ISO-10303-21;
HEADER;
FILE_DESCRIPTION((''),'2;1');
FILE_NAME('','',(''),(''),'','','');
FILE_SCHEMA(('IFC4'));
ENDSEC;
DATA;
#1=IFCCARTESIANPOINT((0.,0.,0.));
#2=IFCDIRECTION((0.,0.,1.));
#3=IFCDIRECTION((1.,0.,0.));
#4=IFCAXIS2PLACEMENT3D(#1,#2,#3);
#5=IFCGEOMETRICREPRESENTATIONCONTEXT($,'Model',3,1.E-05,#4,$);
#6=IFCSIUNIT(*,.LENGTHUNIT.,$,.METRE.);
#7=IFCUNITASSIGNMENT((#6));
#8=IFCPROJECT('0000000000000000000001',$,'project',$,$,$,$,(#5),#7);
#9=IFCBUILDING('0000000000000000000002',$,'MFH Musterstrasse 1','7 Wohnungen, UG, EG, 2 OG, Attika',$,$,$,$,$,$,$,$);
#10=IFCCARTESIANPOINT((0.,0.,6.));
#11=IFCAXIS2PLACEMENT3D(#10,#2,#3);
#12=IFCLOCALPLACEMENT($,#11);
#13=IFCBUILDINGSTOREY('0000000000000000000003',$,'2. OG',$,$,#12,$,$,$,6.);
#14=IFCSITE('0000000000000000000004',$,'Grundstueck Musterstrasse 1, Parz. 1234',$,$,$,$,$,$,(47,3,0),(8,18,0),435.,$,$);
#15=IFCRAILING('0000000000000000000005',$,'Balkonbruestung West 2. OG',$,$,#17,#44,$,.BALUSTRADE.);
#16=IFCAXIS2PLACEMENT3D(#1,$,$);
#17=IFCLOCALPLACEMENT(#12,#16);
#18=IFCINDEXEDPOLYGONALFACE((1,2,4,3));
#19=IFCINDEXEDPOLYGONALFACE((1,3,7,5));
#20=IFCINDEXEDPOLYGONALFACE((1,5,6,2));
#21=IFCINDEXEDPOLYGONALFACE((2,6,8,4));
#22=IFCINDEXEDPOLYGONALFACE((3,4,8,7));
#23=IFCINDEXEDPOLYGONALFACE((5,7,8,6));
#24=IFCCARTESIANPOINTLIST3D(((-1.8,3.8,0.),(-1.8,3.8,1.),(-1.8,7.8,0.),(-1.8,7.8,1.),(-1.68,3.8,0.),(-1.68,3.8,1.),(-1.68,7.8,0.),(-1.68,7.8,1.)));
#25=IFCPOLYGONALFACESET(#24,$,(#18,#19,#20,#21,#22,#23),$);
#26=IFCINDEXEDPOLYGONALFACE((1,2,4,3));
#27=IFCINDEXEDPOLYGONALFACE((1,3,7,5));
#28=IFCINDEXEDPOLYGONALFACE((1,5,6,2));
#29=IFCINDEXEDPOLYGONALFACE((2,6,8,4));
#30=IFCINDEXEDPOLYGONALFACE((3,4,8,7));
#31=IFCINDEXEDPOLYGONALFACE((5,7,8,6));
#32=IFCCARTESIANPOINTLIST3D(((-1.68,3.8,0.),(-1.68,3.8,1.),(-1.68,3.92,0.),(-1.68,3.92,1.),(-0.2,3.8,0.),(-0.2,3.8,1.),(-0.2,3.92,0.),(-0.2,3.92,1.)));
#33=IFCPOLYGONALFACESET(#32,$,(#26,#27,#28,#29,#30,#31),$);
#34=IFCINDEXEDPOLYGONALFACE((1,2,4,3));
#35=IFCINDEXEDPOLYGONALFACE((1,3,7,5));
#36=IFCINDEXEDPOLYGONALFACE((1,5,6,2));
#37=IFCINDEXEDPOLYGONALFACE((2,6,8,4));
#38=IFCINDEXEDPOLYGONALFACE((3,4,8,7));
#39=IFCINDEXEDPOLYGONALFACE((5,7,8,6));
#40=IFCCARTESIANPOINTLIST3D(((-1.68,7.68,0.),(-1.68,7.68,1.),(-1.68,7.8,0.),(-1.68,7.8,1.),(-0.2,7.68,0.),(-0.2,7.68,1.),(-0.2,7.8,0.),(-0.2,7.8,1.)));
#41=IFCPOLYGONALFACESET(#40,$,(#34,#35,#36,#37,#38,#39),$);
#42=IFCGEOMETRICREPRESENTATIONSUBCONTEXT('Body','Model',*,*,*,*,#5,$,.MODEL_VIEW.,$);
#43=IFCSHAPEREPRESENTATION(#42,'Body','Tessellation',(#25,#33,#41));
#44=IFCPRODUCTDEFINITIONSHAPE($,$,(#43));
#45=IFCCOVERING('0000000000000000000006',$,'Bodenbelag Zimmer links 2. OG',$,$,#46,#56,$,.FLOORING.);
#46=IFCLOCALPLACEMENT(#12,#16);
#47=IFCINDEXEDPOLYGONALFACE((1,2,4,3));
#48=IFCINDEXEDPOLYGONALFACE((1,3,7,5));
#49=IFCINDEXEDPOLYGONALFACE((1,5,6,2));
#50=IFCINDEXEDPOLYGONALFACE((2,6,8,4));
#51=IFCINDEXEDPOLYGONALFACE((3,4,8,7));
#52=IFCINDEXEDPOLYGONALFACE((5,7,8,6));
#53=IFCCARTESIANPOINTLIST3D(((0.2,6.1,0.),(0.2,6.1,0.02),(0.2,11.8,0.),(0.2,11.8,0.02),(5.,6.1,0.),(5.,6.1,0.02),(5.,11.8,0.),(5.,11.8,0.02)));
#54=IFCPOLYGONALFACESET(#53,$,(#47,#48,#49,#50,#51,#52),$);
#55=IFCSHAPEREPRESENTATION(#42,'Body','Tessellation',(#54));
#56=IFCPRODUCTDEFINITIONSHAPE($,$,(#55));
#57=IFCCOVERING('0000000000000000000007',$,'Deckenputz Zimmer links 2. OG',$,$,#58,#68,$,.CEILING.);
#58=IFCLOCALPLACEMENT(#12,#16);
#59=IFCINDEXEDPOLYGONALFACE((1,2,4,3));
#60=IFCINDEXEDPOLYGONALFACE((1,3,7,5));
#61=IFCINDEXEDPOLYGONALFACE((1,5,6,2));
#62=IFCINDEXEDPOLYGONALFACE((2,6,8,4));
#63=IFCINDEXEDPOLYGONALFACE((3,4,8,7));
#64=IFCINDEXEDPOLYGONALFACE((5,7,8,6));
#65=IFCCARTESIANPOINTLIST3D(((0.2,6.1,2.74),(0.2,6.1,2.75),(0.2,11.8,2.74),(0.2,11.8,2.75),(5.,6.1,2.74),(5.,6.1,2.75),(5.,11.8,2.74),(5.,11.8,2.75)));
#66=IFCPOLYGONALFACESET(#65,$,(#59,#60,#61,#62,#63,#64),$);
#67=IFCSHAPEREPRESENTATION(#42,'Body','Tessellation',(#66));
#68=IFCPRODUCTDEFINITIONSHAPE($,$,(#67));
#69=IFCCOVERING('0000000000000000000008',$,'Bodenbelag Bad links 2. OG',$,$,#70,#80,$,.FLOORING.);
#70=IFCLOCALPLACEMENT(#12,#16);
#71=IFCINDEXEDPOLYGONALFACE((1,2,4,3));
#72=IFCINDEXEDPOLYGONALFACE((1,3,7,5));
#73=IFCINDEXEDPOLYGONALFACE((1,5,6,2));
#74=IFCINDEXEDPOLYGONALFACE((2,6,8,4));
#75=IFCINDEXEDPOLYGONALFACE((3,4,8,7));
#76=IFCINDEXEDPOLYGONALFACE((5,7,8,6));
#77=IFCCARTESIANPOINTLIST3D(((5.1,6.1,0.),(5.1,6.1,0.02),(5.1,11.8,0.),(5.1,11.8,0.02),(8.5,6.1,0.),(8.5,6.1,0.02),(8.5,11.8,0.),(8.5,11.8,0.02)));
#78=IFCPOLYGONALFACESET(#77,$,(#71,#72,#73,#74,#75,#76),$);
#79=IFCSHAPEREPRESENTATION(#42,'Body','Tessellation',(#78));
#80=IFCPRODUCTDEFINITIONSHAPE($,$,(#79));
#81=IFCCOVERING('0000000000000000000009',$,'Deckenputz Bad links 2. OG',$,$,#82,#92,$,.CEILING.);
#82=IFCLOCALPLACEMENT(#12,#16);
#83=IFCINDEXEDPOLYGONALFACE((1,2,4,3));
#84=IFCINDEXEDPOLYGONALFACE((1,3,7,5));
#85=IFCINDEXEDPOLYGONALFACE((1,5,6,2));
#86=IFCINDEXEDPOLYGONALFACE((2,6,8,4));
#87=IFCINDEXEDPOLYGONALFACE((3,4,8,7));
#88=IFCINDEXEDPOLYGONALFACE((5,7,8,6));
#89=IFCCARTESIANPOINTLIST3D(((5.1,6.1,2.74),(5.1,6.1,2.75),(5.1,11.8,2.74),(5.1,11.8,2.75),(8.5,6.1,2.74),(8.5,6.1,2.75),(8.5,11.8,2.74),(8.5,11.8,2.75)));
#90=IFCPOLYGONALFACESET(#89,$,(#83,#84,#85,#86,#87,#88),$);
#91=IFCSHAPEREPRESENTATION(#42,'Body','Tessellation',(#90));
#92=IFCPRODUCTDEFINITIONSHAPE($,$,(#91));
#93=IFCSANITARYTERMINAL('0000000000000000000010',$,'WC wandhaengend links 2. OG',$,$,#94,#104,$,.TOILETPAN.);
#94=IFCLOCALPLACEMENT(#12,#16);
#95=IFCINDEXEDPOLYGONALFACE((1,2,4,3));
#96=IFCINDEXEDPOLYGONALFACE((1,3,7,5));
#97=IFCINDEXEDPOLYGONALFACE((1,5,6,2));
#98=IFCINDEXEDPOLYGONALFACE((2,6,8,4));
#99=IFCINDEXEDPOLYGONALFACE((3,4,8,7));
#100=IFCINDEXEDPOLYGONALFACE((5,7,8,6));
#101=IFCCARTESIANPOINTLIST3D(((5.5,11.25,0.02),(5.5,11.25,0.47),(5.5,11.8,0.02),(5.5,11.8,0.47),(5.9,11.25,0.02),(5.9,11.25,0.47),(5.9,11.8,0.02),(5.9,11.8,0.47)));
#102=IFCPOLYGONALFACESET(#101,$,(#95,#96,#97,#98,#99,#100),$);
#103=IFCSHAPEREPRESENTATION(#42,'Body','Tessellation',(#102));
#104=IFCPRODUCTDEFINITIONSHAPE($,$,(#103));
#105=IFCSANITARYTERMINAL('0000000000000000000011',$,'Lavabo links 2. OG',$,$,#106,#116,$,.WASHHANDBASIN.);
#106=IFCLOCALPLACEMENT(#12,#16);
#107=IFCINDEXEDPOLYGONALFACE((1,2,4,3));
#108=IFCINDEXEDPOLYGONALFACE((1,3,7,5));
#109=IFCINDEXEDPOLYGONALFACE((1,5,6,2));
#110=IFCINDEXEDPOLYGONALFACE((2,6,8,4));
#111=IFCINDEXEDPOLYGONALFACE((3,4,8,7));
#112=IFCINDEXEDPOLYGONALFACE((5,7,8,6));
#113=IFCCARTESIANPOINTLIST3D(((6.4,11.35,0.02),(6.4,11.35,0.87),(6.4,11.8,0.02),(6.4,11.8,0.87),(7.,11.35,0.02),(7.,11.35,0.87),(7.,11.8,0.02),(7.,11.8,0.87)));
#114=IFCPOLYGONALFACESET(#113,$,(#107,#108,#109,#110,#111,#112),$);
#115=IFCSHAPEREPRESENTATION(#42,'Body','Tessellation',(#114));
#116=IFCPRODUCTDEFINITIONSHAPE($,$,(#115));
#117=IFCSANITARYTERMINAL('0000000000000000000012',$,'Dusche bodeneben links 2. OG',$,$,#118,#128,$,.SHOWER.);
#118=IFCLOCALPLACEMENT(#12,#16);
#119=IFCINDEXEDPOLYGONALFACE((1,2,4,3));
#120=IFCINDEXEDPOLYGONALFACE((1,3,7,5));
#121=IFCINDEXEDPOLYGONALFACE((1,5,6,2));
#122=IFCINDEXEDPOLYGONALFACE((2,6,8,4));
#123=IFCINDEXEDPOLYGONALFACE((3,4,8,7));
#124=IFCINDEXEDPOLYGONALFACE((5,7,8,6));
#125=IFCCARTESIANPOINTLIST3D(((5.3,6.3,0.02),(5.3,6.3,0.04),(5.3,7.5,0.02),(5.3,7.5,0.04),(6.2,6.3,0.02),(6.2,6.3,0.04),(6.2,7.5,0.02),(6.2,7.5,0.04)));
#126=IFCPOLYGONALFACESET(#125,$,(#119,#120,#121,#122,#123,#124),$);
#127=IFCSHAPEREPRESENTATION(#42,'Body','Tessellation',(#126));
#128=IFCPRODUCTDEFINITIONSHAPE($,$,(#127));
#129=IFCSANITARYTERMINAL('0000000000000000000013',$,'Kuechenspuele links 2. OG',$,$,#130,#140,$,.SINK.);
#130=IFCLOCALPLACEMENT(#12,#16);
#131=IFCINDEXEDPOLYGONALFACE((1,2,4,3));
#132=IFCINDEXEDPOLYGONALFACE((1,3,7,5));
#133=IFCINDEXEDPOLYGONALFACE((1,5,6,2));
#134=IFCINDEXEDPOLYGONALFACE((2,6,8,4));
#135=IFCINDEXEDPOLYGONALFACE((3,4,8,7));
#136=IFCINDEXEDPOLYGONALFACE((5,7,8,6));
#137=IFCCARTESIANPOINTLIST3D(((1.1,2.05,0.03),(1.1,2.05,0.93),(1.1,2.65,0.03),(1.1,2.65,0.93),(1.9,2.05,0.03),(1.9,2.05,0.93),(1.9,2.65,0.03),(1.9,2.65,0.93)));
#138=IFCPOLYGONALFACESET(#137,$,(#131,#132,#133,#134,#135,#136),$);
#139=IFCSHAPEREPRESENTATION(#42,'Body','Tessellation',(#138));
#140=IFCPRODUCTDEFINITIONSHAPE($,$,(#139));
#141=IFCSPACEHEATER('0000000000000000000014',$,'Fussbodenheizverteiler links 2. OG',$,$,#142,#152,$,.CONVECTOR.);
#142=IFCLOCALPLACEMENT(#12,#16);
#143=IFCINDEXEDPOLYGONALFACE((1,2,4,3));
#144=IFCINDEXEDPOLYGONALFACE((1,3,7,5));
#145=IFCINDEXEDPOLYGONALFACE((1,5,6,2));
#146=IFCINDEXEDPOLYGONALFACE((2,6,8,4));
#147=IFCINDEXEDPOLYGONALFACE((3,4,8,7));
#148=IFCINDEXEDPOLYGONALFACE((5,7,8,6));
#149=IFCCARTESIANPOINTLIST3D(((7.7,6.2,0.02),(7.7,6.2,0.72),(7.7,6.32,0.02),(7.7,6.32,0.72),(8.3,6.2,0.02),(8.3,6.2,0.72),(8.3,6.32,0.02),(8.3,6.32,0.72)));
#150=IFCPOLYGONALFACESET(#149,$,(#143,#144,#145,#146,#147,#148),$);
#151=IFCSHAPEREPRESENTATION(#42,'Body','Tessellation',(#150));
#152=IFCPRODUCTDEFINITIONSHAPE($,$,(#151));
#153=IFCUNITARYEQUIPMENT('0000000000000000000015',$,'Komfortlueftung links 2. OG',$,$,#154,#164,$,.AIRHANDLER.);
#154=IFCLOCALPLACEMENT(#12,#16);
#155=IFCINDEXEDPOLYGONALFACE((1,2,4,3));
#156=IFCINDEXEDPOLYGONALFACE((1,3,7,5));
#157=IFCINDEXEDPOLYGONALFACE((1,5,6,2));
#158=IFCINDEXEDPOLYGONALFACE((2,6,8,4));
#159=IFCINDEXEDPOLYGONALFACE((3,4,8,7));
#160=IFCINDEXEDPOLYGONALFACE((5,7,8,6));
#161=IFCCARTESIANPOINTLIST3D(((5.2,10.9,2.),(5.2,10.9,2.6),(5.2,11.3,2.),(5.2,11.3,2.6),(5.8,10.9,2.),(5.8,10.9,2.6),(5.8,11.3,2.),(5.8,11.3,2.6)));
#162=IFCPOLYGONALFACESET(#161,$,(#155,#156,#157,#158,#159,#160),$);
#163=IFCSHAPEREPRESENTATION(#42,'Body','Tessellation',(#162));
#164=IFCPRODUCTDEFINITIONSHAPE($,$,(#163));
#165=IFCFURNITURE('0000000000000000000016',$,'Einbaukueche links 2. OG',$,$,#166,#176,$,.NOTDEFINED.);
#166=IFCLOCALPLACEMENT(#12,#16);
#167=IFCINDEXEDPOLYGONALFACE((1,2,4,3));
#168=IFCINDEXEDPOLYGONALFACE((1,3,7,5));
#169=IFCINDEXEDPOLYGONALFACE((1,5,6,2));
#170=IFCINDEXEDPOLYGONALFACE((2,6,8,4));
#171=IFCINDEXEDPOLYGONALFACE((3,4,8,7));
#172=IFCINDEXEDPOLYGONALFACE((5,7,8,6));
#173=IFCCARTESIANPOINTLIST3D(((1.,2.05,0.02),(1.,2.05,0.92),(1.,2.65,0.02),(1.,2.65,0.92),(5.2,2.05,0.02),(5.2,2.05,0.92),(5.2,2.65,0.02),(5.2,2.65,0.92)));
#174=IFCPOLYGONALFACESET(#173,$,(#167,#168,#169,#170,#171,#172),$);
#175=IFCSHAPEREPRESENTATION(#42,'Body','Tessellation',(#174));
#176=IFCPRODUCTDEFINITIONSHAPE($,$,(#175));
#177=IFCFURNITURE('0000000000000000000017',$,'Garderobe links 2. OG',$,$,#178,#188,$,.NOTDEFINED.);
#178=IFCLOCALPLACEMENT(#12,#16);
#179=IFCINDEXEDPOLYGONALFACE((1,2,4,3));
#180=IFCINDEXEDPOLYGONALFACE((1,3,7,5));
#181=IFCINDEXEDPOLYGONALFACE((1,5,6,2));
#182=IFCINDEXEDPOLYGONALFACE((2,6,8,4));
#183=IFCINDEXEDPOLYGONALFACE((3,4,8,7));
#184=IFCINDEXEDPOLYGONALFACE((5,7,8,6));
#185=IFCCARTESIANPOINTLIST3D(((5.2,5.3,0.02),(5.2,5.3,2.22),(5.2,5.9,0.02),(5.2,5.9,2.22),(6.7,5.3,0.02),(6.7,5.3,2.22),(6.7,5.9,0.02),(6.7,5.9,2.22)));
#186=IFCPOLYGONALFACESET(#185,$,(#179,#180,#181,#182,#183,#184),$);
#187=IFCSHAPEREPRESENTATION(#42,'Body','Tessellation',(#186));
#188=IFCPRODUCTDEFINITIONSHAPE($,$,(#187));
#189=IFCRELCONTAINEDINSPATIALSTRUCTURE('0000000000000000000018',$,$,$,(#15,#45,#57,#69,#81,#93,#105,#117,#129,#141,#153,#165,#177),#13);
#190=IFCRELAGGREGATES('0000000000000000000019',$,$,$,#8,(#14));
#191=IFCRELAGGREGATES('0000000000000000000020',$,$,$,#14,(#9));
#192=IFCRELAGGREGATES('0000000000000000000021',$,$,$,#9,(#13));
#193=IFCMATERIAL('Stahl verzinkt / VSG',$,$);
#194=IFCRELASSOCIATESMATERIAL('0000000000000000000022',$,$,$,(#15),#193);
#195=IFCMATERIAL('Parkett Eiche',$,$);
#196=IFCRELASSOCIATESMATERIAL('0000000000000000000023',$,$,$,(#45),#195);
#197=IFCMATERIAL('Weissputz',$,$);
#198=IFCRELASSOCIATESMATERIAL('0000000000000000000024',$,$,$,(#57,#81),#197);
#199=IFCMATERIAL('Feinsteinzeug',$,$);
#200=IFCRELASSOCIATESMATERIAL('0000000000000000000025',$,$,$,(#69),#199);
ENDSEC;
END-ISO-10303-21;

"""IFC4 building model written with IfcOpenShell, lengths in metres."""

from ifc_helpers import new_model, si_unit, frame, frame_2d, origin_with_axes, place, context, subcontext, project, spatial, rectangle, extrude, material, element, save


model = new_model("IFC4")

# Units and contexts
model_context = context("Model", 3, precision=1e-05, world=origin_with_axes())
body_context = subcontext(model_context, "Body", "Model", "MODEL_VIEW")
ifc_project = project(units=[si_unit("LENGTHUNIT", "METRE")], contexts=[model_context])

# Site, building, storey
site = spatial("IfcSite", under=ifc_project, Name="Grundstueck Musterstrasse 1, Parz. 1234", RefLatitude=(47, 3, 0), RefLongitude=(8, 18, 0), RefElevation=435.0)
building = spatial("IfcBuilding", under=site, Name="MFH Musterstrasse 1", Description="7 Wohnungen, UG, EG, 2 OG, Attika")
storey_placement = place(None, frame((0.0, 0.0, 6.0), z_axis=(0.0, 0.0, 1.0), x_axis=(1.0, 0.0, 0.0)))
storey = spatial("IfcBuildingStorey", under=building, at=storey_placement, Name="2. OG", Elevation=6.0)

# Railing
ifc_material_1 = material(Name="Stahl verzinkt / VSG")
railing_placement = place(storey_placement, frame((-1.8, 3.8, 0.0), z_axis=(0.0, 0.0, 1.0), x_axis=(1.0, 0.0, 0.0)))
element("IfcRailing", 1, at=railing_placement, inside=storey, material=ifc_material_1, Name="Balkonbruestung West 2. OG", PredefinedType="BALUSTRADE", context=body_context, shape_type="SweptSolid", body=[
    extrude(rectangle(XDim=0.12, YDim=4.0, at=frame_2d((0.06, 2.0))), origin_with_axes(), (0.0, 0.0, 1.0), 1.0),
    extrude(rectangle(XDim=1.48, YDim=0.12, at=frame_2d((0.86, 0.06))), origin_with_axes(), (0.0, 0.0, 1.0), 1.0),
    extrude(rectangle(XDim=1.48, YDim=0.12, at=frame_2d((0.86, 3.94))), origin_with_axes(), (0.0, 0.0, 1.0), 1.0),
])

# Coverings
ifc_material_2 = material(Name="Parkett Eiche")
covering_1_placement = place(storey_placement, frame((0.2, 6.1, 0.0), z_axis=(0.0, 0.0, 1.0), x_axis=(1.0, 0.0, 0.0)))
element("IfcCovering", 2, at=covering_1_placement, inside=storey, material=ifc_material_2, Name="Bodenbelag Zimmer links 2. OG", PredefinedType="FLOORING", context=body_context, shape_type="SweptSolid", body=[
    extrude(rectangle(XDim=4.8, YDim=5.7, at=frame_2d((2.4, 2.85))), origin_with_axes(), (0.0, 0.0, 1.0), 0.02),
])
ifc_material_3 = material(Name="Weissputz")
covering_2_placement = place(storey_placement, frame((0.2, 6.1, 2.74), z_axis=(0.0, 0.0, 1.0), x_axis=(1.0, 0.0, 0.0)))
element("IfcCovering", 3, at=covering_2_placement, inside=storey, material=ifc_material_3, Name="Deckenputz Zimmer links 2. OG", PredefinedType="CEILING", context=body_context, shape_type="SweptSolid", body=[
    extrude(rectangle(XDim=4.8, YDim=5.7, at=frame_2d((2.4, 2.85))), origin_with_axes(), (0.0, 0.0, 1.0), 0.01),
])
ifc_material_4 = material(Name="Feinsteinzeug")
covering_3_placement = place(storey_placement, frame((5.1, 6.1, 0.0), z_axis=(0.0, 0.0, 1.0), x_axis=(1.0, 0.0, 0.0)))
element("IfcCovering", 4, at=covering_3_placement, inside=storey, material=ifc_material_4, Name="Bodenbelag Bad links 2. OG", PredefinedType="FLOORING", context=body_context, shape_type="SweptSolid", body=[
    extrude(rectangle(XDim=3.4, YDim=5.7, at=frame_2d((1.7, 2.85))), origin_with_axes(), (0.0, 0.0, 1.0), 0.02),
])
covering_4_placement = place(storey_placement, frame((5.1, 6.1, 2.74), z_axis=(0.0, 0.0, 1.0), x_axis=(1.0, 0.0, 0.0)))
element("IfcCovering", 5, at=covering_4_placement, inside=storey, material=ifc_material_3, Name="Deckenputz Bad links 2. OG", PredefinedType="CEILING", context=body_context, shape_type="SweptSolid", body=[
    extrude(rectangle(XDim=3.4, YDim=5.7, at=frame_2d((1.7, 2.85))), origin_with_axes(), (0.0, 0.0, 1.0), 0.01),
])

# Sanitary terminals
sanitary_terminal_1_placement = place(storey_placement, frame((5.5, 11.25, 0.02), z_axis=(0.0, 0.0, 1.0), x_axis=(1.0, 0.0, 0.0)))
element("IfcSanitaryTerminal", 6, at=sanitary_terminal_1_placement, inside=storey, Name="WC wandhaengend links 2. OG", PredefinedType="TOILETPAN", context=body_context, shape_type="SweptSolid", body=[
    extrude(rectangle(XDim=0.4, YDim=0.55, at=frame_2d((0.2, 0.275))), origin_with_axes(), (0.0, 0.0, 1.0), 0.45),
])
sanitary_terminal_2_placement = place(storey_placement, frame((6.4, 11.35, 0.02), z_axis=(0.0, 0.0, 1.0), x_axis=(1.0, 0.0, 0.0)))
element("IfcSanitaryTerminal", 7, at=sanitary_terminal_2_placement, inside=storey, Name="Lavabo links 2. OG", PredefinedType="WASHHANDBASIN", context=body_context, shape_type="SweptSolid", body=[
    extrude(rectangle(XDim=0.6, YDim=0.45, at=frame_2d((0.3, 0.225))), origin_with_axes(), (0.0, 0.0, 1.0), 0.85),
])
sanitary_terminal_3_placement = place(storey_placement, frame((5.3, 6.3, 0.02), z_axis=(0.0, 0.0, 1.0), x_axis=(1.0, 0.0, 0.0)))
element("IfcSanitaryTerminal", 8, at=sanitary_terminal_3_placement, inside=storey, Name="Dusche bodeneben links 2. OG", PredefinedType="SHOWER", context=body_context, shape_type="SweptSolid", body=[
    extrude(rectangle(XDim=0.9, YDim=1.2, at=frame_2d((0.45, 0.6))), origin_with_axes(), (0.0, 0.0, 1.0), 0.02),
])
sanitary_terminal_4_placement = place(storey_placement, frame((1.1, 2.05, 0.03), z_axis=(0.0, 0.0, 1.0), x_axis=(1.0, 0.0, 0.0)))
element("IfcSanitaryTerminal", 9, at=sanitary_terminal_4_placement, inside=storey, Name="Kuechenspuele links 2. OG", PredefinedType="SINK", context=body_context, shape_type="SweptSolid", body=[
    extrude(rectangle(XDim=0.8, YDim=0.6, at=frame_2d((0.4, 0.3))), origin_with_axes(), (0.0, 0.0, 1.0), 0.9),
])

# Space heater
space_heater_placement = place(storey_placement, frame((7.7, 6.2, 0.02), z_axis=(0.0, 0.0, 1.0), x_axis=(1.0, 0.0, 0.0)))
element("IfcSpaceHeater", 10, at=space_heater_placement, inside=storey, Name="Fussbodenheizverteiler links 2. OG", PredefinedType="CONVECTOR", context=body_context, shape_type="SweptSolid", body=[
    extrude(rectangle(XDim=0.6, YDim=0.12, at=frame_2d((0.3, 0.06))), origin_with_axes(), (0.0, 0.0, 1.0), 0.7),
])

# Unitary equipment
unitary_equipment_placement = place(storey_placement, frame((5.2, 10.9, 2.0), z_axis=(0.0, 0.0, 1.0), x_axis=(1.0, 0.0, 0.0)))
element("IfcUnitaryEquipment", 11, at=unitary_equipment_placement, inside=storey, Name="Komfortlueftung links 2. OG", PredefinedType="AIRHANDLER", context=body_context, shape_type="SweptSolid", body=[
    extrude(rectangle(XDim=0.6, YDim=0.4, at=frame_2d((0.3, 0.2))), origin_with_axes(), (0.0, 0.0, 1.0), 0.6),
])

# Furniture
furniture_1_placement = place(storey_placement, frame((1.0, 2.05, 0.02), z_axis=(0.0, 0.0, 1.0), x_axis=(1.0, 0.0, 0.0)))
element("IfcFurniture", 12, at=furniture_1_placement, inside=storey, Name="Einbaukueche links 2. OG", PredefinedType="NOTDEFINED", context=body_context, shape_type="SweptSolid", body=[
    extrude(rectangle(XDim=4.2, YDim=0.6, at=frame_2d((2.1, 0.3))), origin_with_axes(), (0.0, 0.0, 1.0), 0.9),
])
furniture_2_placement = place(storey_placement, frame((5.2, 5.3, 0.02), z_axis=(0.0, 0.0, 1.0), x_axis=(1.0, 0.0, 0.0)))
element("IfcFurniture", 13, at=furniture_2_placement, inside=storey, Name="Garderobe links 2. OG", PredefinedType="NOTDEFINED", context=body_context, shape_type="SweptSolid", body=[
    extrude(rectangle(XDim=1.5, YDim=0.6, at=frame_2d((0.75, 0.3))), origin_with_axes(), (0.0, 0.0, 1.0), 2.2),
])

save(model, "model.ifc")
